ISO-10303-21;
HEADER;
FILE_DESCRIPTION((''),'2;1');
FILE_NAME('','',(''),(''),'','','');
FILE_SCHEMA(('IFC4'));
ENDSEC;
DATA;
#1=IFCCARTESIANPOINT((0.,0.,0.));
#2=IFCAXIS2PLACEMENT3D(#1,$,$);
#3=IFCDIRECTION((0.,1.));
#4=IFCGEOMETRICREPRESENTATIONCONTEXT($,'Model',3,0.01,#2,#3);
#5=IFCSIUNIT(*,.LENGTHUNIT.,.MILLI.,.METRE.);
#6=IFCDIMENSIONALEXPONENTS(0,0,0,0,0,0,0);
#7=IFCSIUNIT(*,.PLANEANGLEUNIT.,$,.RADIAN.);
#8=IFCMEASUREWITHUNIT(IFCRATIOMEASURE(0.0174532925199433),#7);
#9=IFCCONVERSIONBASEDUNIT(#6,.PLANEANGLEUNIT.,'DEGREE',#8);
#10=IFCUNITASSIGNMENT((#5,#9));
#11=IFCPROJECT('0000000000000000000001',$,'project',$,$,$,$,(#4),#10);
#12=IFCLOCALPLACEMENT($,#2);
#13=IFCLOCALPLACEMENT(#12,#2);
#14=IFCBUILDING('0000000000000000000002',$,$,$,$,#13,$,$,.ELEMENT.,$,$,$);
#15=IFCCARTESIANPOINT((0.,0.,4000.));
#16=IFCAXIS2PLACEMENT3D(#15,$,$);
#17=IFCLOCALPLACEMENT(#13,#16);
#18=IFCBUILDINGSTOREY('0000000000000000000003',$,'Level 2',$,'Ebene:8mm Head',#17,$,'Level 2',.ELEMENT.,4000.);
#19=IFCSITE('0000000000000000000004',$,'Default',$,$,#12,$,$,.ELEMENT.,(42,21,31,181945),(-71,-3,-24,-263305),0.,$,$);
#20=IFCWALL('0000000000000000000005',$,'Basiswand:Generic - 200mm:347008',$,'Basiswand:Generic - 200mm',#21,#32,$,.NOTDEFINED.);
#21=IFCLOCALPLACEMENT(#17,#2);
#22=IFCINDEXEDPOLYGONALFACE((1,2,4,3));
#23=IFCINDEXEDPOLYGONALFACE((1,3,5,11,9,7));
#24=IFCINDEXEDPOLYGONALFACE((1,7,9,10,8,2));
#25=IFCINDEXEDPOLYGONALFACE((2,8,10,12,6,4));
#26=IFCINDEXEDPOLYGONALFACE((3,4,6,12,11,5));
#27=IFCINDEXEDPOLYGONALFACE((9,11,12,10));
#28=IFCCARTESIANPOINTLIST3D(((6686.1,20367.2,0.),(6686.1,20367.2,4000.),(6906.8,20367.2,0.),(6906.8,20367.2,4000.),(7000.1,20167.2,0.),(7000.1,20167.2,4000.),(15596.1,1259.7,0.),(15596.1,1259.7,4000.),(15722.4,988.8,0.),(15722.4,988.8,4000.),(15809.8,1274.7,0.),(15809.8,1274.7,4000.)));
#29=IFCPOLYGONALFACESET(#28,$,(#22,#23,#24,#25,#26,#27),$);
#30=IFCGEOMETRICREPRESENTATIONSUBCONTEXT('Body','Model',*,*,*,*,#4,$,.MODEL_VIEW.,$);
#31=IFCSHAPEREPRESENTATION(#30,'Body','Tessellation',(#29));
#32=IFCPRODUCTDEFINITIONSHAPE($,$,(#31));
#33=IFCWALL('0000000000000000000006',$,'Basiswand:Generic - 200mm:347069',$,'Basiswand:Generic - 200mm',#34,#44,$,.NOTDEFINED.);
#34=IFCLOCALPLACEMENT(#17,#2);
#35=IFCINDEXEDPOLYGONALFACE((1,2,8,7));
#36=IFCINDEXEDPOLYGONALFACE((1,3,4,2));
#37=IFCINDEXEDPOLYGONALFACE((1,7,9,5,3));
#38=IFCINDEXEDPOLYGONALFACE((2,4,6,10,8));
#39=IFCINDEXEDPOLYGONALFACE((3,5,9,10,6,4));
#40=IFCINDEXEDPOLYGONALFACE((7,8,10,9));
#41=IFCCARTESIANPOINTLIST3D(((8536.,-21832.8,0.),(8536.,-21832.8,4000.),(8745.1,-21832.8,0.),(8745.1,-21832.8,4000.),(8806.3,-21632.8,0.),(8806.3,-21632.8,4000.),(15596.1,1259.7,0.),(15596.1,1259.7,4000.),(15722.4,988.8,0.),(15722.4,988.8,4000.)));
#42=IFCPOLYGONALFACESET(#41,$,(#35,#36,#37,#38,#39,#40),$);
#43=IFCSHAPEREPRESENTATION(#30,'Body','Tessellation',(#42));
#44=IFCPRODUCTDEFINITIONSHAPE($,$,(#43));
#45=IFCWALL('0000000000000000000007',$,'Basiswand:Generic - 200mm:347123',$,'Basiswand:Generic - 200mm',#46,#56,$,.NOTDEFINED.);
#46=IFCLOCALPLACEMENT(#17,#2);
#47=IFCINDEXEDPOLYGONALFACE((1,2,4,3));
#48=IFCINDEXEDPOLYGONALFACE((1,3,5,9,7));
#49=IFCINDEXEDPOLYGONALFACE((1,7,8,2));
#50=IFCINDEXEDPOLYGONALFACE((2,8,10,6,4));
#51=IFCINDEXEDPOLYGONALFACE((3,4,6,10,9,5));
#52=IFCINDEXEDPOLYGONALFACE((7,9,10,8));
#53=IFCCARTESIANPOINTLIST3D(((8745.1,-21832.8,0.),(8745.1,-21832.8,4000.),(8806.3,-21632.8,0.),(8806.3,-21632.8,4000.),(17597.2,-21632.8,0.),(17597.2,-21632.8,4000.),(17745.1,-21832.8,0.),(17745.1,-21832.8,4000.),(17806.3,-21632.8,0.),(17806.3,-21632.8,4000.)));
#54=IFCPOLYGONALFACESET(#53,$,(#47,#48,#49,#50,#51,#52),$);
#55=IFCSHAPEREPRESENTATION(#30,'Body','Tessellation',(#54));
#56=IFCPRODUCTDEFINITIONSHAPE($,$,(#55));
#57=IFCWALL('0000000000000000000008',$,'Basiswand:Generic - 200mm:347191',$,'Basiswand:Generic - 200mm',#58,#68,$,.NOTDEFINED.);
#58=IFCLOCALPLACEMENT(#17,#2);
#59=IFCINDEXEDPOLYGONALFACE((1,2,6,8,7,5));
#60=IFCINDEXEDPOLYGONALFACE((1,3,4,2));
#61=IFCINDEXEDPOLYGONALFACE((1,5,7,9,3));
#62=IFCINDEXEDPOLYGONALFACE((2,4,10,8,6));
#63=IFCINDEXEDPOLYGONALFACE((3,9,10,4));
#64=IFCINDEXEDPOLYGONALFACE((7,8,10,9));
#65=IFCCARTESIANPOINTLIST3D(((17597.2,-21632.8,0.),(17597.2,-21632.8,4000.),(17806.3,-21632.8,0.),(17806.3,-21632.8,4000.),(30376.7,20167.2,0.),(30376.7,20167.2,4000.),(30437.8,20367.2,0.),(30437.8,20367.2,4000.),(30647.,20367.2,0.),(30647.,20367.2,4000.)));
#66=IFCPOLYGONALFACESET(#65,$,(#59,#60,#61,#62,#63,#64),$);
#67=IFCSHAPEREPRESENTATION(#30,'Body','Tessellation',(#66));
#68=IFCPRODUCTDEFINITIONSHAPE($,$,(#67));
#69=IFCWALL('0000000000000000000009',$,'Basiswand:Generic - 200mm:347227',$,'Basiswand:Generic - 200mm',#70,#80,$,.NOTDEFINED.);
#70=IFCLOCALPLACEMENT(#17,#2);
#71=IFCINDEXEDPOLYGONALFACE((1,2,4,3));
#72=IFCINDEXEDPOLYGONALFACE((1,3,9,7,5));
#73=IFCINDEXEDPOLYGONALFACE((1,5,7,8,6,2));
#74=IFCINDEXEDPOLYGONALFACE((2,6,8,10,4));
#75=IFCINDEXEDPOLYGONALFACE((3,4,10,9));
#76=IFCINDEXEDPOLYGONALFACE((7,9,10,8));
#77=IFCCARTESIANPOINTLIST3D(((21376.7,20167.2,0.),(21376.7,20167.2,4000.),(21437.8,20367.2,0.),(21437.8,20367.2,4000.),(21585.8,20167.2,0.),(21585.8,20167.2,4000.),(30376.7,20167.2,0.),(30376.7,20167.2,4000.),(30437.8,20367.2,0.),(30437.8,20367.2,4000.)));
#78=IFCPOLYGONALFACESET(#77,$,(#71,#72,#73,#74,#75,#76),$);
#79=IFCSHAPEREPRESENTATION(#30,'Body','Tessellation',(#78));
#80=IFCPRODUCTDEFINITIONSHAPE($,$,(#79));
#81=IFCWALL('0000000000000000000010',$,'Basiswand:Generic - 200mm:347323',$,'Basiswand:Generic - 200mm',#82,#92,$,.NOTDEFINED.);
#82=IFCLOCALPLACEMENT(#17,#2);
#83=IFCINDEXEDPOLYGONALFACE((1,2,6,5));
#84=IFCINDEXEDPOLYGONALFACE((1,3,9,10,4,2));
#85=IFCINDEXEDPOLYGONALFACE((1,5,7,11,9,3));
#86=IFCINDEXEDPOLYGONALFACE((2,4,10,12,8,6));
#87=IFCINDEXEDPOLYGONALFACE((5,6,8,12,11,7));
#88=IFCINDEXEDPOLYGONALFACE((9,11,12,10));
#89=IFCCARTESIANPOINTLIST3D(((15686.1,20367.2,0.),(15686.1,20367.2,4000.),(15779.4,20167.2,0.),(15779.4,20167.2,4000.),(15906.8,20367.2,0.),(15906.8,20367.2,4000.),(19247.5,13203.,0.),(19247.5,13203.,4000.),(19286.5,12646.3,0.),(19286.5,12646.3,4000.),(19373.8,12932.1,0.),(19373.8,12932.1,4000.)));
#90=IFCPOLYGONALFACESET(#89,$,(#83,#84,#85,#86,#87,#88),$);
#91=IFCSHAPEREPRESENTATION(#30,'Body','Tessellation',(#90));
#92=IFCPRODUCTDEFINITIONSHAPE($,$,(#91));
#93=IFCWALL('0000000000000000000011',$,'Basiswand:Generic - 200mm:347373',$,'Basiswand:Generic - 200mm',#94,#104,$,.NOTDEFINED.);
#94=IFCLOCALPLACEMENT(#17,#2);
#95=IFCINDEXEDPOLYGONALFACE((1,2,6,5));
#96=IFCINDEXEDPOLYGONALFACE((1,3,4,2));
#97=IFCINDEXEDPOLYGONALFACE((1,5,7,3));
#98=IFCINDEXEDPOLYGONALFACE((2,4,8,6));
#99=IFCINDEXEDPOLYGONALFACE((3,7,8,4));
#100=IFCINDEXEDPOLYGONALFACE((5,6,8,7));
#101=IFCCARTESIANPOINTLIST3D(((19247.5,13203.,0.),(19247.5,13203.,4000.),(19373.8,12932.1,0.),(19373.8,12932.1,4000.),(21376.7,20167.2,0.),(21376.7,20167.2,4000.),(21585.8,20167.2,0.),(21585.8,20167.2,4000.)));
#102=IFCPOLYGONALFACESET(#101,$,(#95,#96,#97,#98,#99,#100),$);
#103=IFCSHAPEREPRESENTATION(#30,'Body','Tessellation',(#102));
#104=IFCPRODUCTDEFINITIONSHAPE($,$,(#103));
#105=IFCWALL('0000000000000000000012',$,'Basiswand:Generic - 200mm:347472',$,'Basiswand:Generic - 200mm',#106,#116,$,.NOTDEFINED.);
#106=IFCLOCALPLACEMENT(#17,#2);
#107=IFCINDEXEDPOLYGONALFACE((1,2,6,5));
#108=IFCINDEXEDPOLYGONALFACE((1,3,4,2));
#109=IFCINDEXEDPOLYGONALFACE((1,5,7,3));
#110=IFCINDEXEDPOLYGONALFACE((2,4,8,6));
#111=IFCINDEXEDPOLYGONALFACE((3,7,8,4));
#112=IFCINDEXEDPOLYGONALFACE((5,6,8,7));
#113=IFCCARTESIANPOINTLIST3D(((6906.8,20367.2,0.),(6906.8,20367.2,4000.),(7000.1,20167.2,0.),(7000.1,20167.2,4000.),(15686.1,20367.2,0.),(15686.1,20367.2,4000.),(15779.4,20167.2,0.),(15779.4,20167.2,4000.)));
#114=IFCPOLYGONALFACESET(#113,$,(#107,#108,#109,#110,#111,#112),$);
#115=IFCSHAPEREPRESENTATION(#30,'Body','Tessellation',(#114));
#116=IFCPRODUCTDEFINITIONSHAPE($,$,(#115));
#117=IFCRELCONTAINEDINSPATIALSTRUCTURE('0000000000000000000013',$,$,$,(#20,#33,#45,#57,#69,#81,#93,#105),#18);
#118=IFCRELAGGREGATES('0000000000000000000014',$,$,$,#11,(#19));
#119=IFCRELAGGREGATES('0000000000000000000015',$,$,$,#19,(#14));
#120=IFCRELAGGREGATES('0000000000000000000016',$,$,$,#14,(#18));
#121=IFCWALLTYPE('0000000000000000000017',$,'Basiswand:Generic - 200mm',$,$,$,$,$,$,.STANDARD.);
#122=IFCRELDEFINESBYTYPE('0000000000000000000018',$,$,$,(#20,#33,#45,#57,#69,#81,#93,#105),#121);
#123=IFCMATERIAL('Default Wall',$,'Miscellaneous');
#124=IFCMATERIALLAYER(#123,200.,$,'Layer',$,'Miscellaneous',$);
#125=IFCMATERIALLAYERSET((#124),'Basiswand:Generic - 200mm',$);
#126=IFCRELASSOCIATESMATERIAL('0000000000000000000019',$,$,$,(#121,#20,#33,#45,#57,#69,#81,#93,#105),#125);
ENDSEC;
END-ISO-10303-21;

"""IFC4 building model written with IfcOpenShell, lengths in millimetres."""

from ifc_helpers import new_model, entity, si_unit, converted_unit, direction, frame, origin, place, context, subcontext, project, spatial, polyline, outline, extrude, material, layer, layer_set, layer_usage, type_object, element, save


model = new_model("IFC4")

# Units and contexts
model_context = context("Model", 3, precision=0.01, world=origin(), true_north=direction((0.0, 1.0)))
body_context = subcontext(model_context, "Body", "Model", "MODEL_VIEW")
ifc_project = project(units=[si_unit("LENGTHUNIT", "METRE", prefix="MILLI"), converted_unit("PLANEANGLEUNIT", "DEGREE", entity("IfcRatioMeasure", 0.0174532925199433), si_unit("PLANEANGLEUNIT", "RADIAN"), dimensions=[0, 0, 0, 0, 0, 0, 0])], contexts=[model_context])

# Site, building, storey
site_placement = place(None, origin())
site = spatial("IfcSite", under=ifc_project, at=site_placement, Name="Default", CompositionType="ELEMENT", RefLatitude=(42, 21, 31, 181945), RefLongitude=(-71, -3, -24, -263305), RefElevation=0.0)
building_placement = place(site_placement, origin())
building = spatial("IfcBuilding", under=site, at=building_placement, CompositionType="ELEMENT")
storey_placement = place(building_placement, frame((0.0, 0.0, 4000.0)))
storey = spatial("IfcBuildingStorey", under=building, at=storey_placement, Name="Level 2", ObjectType="Ebene:8mm Head", LongName="Level 2", CompositionType="ELEMENT", Elevation=4000.0)

# Walls
ifc_material = material(Name="Default Wall", Category="Miscellaneous")
ifc_layer = layer(ifc_material, 200.0, Name="Layer", Category="Miscellaneous")
ifc_layer_set = layer_set([ifc_layer], Name="Basiswand:Generic - 200mm")
ifc_layer_usage_1 = layer_usage(ifc_layer_set, "AXIS2", "NEGATIVE", 100.0)
wall_type = type_object("IfcWallType", Name="Basiswand:Generic - 200mm", PredefinedType="STANDARD", material=ifc_layer_set)
wall_1_placement = place(storey_placement, frame((6776.8, 20409.5, 0.0), z_axis=(0.0, 0.0, 1.0), x_axis=(0.422618, -0.906308, 0.0)))
element("IfcWall", 1, at=wall_1_placement, inside=storey, type_object=wall_type, material=ifc_layer_usage_1, Name="Basiswand:Generic - 200mm:347008", ObjectType="Basiswand:Generic - 200mm", PredefinedType="NOTDEFINED", context=body_context, shape_type="SweptSolid", body=[
    extrude(outline(polyline([(21381.7, -100.0), (21159.5, 100.0), (313.9, 100.0), (93.3, 100.0), (0.0, -100.0), (21082.8, -100.0), (21381.7, -100.0)])), origin(), (0.0, 0.0, 1.0), 4000.0),
])
ifc_layer_usage_2 = layer_usage(ifc_layer_set, "AXIS2", "NEGATIVE", 100.0)
wall_2_placement = place(storey_placement, frame((15691.7, 1230.5, 0.0), z_axis=(0.0, 0.0, 1.0), x_axis=(-0.292372, -0.956305, 0.0)))
element("IfcWall", 2, at=wall_2_placement, inside=storey, type_object=wall_type, material=ifc_layer_usage_2, Name="Basiswand:Generic - 200mm:347069", ObjectType="Basiswand:Generic - 200mm", PredefinedType="NOTDEFINED", context=body_context, shape_type="SweptSolid", body=[
    extrude(outline(polyline([(24147.7, -100.0), (24086.5, 100.0), (23877.4, 100.0), (222.1, 100.0), (0.0, -100.0), (24147.7, -100.0)])), origin(), (0.0, 0.0, 1.0), 4000.0),
])
ifc_layer_usage_3 = layer_usage(ifc_layer_set, "AXIS2", "NEGATIVE", 100.0)
wall_3_placement = place(storey_placement, frame((8745.1, -21732.8, 0.0)))
element("IfcWall", 3, at=wall_3_placement, inside=storey, type_object=wall_type, material=ifc_layer_usage_3, Name="Basiswand:Generic - 200mm:347123", ObjectType="Basiswand:Generic - 200mm", PredefinedType="NOTDEFINED", context=body_context, shape_type="SweptSolid", body=[
    extrude(outline(polyline([(9000.0, -100.0), (9061.1, 100.0), (8852.0, 100.0), (61.1, 100.0), (0.0, -100.0), (9000.0, -100.0)])), origin(), (0.0, 0.0, 1.0), 4000.0),
])
ifc_layer_usage_4 = layer_usage(ifc_layer_set, "AXIS2", "NEGATIVE", 100.0)
wall_4_placement = place(storey_placement, frame((17692.8, -21662.0, 0.0), z_axis=(0.0, 0.0, 1.0), x_axis=(0.292372, 0.956305, 0.0)))
element("IfcWall", 4, at=wall_4_placement, inside=storey, type_object=wall_type, material=ifc_layer_usage_4, Name="Basiswand:Generic - 200mm:347191", ObjectType="Basiswand:Generic - 200mm", PredefinedType="NOTDEFINED", context=body_context, shape_type="SweptSolid", body=[
    extrude(outline(polyline([(43980.2, -100.0), (43919.1, 100.0), (43709.9, 100.0), (0.0, 100.0), (61.1, -100.0), (43980.2, -100.0)])), origin(), (0.0, 0.0, 1.0), 4000.0),
])
ifc_layer_usage_5 = layer_usage(ifc_layer_set, "AXIS2", "NEGATIVE", 100.0)
wall_5_placement = place(storey_placement, frame((30437.8, 20267.2, 0.0), z_axis=(0.0, 0.0, 1.0), x_axis=(-1.0, 0.0, 0.0)))
element("IfcWall", 5, at=wall_5_placement, inside=storey, type_object=wall_type, material=ifc_layer_usage_5, Name="Basiswand:Generic - 200mm:347227", ObjectType="Basiswand:Generic - 200mm", PredefinedType="NOTDEFINED", context=body_context, shape_type="SweptSolid", body=[
    extrude(outline(polyline([(9000.0, -100.0), (9061.1, 100.0), (8852.0, 100.0), (61.1, 100.0), (0.0, -100.0), (9000.0, -100.0)])), origin(), (0.0, 0.0, 1.0), 4000.0),
])
ifc_layer_usage_6 = layer_usage(ifc_layer_set, "AXIS2", "NEGATIVE", 100.0)
wall_6_placement = place(storey_placement, frame((15776.8, 20409.5, 0.0), z_axis=(0.0, 0.0, 1.0), x_axis=(0.422618, -0.906308, 0.0)))
element("IfcWall", 6, at=wall_6_placement, inside=storey, type_object=wall_type, material=ifc_layer_usage_6, Name="Basiswand:Generic - 200mm:347323", ObjectType="Basiswand:Generic - 200mm", PredefinedType="NOTDEFINED", context=body_context, shape_type="SweptSolid", body=[
    extrude(outline(polyline([(8519.1, -100.0), (8297.0, 100.0), (7998.1, 100.0), (93.3, 100.0), (0.0, -100.0), (220.7, -100.0), (8519.1, -100.0)])), origin(), (0.0, 0.0, 1.0), 4000.0),
])
ifc_layer_usage_7 = layer_usage(ifc_layer_set, "AXIS2", "NEGATIVE", 100.0)
wall_7_placement = place(storey_placement, frame((19278.2, 12961.4, 0.0), z_axis=(0.0, 0.0, 1.0), x_axis=(0.292372, 0.956305, 0.0)))
element("IfcWall", 7, at=wall_7_placement, inside=storey, type_object=wall_type, material=ifc_layer_usage_7, Name="Basiswand:Generic - 200mm:347373", ObjectType="Basiswand:Generic - 200mm", PredefinedType="NOTDEFINED", context=body_context, shape_type="SweptSolid", body=[
    extrude(outline(polyline([(7565.7, -100.0), (7504.5, 100.0), (222.1, 100.0), (0.0, -100.0), (7565.7, -100.0)])), origin(), (0.0, 0.0, 1.0), 4000.0),
])
ifc_layer_usage_8 = layer_usage(ifc_layer_set, "AXIS2", "NEGATIVE", 100.0)
wall_8_placement = place(storey_placement, frame((15779.4, 20267.2, 0.0), z_axis=(0.0, 0.0, 1.0), x_axis=(-1.0, 0.0, 0.0)))
element("IfcWall", 8, at=wall_8_placement, inside=storey, type_object=wall_type, material=ifc_layer_usage_8, Name="Basiswand:Generic - 200mm:347472", ObjectType="Basiswand:Generic - 200mm", PredefinedType="NOTDEFINED", context=body_context, shape_type="SweptSolid", body=[
    extrude(outline(polyline([(8872.6, -100.0), (8779.3, 100.0), (0.0, 100.0), (93.3, -100.0), (8872.6, -100.0)])), origin(), (0.0, 0.0, 1.0), 4000.0),
])

save(model, "model.ifc")
